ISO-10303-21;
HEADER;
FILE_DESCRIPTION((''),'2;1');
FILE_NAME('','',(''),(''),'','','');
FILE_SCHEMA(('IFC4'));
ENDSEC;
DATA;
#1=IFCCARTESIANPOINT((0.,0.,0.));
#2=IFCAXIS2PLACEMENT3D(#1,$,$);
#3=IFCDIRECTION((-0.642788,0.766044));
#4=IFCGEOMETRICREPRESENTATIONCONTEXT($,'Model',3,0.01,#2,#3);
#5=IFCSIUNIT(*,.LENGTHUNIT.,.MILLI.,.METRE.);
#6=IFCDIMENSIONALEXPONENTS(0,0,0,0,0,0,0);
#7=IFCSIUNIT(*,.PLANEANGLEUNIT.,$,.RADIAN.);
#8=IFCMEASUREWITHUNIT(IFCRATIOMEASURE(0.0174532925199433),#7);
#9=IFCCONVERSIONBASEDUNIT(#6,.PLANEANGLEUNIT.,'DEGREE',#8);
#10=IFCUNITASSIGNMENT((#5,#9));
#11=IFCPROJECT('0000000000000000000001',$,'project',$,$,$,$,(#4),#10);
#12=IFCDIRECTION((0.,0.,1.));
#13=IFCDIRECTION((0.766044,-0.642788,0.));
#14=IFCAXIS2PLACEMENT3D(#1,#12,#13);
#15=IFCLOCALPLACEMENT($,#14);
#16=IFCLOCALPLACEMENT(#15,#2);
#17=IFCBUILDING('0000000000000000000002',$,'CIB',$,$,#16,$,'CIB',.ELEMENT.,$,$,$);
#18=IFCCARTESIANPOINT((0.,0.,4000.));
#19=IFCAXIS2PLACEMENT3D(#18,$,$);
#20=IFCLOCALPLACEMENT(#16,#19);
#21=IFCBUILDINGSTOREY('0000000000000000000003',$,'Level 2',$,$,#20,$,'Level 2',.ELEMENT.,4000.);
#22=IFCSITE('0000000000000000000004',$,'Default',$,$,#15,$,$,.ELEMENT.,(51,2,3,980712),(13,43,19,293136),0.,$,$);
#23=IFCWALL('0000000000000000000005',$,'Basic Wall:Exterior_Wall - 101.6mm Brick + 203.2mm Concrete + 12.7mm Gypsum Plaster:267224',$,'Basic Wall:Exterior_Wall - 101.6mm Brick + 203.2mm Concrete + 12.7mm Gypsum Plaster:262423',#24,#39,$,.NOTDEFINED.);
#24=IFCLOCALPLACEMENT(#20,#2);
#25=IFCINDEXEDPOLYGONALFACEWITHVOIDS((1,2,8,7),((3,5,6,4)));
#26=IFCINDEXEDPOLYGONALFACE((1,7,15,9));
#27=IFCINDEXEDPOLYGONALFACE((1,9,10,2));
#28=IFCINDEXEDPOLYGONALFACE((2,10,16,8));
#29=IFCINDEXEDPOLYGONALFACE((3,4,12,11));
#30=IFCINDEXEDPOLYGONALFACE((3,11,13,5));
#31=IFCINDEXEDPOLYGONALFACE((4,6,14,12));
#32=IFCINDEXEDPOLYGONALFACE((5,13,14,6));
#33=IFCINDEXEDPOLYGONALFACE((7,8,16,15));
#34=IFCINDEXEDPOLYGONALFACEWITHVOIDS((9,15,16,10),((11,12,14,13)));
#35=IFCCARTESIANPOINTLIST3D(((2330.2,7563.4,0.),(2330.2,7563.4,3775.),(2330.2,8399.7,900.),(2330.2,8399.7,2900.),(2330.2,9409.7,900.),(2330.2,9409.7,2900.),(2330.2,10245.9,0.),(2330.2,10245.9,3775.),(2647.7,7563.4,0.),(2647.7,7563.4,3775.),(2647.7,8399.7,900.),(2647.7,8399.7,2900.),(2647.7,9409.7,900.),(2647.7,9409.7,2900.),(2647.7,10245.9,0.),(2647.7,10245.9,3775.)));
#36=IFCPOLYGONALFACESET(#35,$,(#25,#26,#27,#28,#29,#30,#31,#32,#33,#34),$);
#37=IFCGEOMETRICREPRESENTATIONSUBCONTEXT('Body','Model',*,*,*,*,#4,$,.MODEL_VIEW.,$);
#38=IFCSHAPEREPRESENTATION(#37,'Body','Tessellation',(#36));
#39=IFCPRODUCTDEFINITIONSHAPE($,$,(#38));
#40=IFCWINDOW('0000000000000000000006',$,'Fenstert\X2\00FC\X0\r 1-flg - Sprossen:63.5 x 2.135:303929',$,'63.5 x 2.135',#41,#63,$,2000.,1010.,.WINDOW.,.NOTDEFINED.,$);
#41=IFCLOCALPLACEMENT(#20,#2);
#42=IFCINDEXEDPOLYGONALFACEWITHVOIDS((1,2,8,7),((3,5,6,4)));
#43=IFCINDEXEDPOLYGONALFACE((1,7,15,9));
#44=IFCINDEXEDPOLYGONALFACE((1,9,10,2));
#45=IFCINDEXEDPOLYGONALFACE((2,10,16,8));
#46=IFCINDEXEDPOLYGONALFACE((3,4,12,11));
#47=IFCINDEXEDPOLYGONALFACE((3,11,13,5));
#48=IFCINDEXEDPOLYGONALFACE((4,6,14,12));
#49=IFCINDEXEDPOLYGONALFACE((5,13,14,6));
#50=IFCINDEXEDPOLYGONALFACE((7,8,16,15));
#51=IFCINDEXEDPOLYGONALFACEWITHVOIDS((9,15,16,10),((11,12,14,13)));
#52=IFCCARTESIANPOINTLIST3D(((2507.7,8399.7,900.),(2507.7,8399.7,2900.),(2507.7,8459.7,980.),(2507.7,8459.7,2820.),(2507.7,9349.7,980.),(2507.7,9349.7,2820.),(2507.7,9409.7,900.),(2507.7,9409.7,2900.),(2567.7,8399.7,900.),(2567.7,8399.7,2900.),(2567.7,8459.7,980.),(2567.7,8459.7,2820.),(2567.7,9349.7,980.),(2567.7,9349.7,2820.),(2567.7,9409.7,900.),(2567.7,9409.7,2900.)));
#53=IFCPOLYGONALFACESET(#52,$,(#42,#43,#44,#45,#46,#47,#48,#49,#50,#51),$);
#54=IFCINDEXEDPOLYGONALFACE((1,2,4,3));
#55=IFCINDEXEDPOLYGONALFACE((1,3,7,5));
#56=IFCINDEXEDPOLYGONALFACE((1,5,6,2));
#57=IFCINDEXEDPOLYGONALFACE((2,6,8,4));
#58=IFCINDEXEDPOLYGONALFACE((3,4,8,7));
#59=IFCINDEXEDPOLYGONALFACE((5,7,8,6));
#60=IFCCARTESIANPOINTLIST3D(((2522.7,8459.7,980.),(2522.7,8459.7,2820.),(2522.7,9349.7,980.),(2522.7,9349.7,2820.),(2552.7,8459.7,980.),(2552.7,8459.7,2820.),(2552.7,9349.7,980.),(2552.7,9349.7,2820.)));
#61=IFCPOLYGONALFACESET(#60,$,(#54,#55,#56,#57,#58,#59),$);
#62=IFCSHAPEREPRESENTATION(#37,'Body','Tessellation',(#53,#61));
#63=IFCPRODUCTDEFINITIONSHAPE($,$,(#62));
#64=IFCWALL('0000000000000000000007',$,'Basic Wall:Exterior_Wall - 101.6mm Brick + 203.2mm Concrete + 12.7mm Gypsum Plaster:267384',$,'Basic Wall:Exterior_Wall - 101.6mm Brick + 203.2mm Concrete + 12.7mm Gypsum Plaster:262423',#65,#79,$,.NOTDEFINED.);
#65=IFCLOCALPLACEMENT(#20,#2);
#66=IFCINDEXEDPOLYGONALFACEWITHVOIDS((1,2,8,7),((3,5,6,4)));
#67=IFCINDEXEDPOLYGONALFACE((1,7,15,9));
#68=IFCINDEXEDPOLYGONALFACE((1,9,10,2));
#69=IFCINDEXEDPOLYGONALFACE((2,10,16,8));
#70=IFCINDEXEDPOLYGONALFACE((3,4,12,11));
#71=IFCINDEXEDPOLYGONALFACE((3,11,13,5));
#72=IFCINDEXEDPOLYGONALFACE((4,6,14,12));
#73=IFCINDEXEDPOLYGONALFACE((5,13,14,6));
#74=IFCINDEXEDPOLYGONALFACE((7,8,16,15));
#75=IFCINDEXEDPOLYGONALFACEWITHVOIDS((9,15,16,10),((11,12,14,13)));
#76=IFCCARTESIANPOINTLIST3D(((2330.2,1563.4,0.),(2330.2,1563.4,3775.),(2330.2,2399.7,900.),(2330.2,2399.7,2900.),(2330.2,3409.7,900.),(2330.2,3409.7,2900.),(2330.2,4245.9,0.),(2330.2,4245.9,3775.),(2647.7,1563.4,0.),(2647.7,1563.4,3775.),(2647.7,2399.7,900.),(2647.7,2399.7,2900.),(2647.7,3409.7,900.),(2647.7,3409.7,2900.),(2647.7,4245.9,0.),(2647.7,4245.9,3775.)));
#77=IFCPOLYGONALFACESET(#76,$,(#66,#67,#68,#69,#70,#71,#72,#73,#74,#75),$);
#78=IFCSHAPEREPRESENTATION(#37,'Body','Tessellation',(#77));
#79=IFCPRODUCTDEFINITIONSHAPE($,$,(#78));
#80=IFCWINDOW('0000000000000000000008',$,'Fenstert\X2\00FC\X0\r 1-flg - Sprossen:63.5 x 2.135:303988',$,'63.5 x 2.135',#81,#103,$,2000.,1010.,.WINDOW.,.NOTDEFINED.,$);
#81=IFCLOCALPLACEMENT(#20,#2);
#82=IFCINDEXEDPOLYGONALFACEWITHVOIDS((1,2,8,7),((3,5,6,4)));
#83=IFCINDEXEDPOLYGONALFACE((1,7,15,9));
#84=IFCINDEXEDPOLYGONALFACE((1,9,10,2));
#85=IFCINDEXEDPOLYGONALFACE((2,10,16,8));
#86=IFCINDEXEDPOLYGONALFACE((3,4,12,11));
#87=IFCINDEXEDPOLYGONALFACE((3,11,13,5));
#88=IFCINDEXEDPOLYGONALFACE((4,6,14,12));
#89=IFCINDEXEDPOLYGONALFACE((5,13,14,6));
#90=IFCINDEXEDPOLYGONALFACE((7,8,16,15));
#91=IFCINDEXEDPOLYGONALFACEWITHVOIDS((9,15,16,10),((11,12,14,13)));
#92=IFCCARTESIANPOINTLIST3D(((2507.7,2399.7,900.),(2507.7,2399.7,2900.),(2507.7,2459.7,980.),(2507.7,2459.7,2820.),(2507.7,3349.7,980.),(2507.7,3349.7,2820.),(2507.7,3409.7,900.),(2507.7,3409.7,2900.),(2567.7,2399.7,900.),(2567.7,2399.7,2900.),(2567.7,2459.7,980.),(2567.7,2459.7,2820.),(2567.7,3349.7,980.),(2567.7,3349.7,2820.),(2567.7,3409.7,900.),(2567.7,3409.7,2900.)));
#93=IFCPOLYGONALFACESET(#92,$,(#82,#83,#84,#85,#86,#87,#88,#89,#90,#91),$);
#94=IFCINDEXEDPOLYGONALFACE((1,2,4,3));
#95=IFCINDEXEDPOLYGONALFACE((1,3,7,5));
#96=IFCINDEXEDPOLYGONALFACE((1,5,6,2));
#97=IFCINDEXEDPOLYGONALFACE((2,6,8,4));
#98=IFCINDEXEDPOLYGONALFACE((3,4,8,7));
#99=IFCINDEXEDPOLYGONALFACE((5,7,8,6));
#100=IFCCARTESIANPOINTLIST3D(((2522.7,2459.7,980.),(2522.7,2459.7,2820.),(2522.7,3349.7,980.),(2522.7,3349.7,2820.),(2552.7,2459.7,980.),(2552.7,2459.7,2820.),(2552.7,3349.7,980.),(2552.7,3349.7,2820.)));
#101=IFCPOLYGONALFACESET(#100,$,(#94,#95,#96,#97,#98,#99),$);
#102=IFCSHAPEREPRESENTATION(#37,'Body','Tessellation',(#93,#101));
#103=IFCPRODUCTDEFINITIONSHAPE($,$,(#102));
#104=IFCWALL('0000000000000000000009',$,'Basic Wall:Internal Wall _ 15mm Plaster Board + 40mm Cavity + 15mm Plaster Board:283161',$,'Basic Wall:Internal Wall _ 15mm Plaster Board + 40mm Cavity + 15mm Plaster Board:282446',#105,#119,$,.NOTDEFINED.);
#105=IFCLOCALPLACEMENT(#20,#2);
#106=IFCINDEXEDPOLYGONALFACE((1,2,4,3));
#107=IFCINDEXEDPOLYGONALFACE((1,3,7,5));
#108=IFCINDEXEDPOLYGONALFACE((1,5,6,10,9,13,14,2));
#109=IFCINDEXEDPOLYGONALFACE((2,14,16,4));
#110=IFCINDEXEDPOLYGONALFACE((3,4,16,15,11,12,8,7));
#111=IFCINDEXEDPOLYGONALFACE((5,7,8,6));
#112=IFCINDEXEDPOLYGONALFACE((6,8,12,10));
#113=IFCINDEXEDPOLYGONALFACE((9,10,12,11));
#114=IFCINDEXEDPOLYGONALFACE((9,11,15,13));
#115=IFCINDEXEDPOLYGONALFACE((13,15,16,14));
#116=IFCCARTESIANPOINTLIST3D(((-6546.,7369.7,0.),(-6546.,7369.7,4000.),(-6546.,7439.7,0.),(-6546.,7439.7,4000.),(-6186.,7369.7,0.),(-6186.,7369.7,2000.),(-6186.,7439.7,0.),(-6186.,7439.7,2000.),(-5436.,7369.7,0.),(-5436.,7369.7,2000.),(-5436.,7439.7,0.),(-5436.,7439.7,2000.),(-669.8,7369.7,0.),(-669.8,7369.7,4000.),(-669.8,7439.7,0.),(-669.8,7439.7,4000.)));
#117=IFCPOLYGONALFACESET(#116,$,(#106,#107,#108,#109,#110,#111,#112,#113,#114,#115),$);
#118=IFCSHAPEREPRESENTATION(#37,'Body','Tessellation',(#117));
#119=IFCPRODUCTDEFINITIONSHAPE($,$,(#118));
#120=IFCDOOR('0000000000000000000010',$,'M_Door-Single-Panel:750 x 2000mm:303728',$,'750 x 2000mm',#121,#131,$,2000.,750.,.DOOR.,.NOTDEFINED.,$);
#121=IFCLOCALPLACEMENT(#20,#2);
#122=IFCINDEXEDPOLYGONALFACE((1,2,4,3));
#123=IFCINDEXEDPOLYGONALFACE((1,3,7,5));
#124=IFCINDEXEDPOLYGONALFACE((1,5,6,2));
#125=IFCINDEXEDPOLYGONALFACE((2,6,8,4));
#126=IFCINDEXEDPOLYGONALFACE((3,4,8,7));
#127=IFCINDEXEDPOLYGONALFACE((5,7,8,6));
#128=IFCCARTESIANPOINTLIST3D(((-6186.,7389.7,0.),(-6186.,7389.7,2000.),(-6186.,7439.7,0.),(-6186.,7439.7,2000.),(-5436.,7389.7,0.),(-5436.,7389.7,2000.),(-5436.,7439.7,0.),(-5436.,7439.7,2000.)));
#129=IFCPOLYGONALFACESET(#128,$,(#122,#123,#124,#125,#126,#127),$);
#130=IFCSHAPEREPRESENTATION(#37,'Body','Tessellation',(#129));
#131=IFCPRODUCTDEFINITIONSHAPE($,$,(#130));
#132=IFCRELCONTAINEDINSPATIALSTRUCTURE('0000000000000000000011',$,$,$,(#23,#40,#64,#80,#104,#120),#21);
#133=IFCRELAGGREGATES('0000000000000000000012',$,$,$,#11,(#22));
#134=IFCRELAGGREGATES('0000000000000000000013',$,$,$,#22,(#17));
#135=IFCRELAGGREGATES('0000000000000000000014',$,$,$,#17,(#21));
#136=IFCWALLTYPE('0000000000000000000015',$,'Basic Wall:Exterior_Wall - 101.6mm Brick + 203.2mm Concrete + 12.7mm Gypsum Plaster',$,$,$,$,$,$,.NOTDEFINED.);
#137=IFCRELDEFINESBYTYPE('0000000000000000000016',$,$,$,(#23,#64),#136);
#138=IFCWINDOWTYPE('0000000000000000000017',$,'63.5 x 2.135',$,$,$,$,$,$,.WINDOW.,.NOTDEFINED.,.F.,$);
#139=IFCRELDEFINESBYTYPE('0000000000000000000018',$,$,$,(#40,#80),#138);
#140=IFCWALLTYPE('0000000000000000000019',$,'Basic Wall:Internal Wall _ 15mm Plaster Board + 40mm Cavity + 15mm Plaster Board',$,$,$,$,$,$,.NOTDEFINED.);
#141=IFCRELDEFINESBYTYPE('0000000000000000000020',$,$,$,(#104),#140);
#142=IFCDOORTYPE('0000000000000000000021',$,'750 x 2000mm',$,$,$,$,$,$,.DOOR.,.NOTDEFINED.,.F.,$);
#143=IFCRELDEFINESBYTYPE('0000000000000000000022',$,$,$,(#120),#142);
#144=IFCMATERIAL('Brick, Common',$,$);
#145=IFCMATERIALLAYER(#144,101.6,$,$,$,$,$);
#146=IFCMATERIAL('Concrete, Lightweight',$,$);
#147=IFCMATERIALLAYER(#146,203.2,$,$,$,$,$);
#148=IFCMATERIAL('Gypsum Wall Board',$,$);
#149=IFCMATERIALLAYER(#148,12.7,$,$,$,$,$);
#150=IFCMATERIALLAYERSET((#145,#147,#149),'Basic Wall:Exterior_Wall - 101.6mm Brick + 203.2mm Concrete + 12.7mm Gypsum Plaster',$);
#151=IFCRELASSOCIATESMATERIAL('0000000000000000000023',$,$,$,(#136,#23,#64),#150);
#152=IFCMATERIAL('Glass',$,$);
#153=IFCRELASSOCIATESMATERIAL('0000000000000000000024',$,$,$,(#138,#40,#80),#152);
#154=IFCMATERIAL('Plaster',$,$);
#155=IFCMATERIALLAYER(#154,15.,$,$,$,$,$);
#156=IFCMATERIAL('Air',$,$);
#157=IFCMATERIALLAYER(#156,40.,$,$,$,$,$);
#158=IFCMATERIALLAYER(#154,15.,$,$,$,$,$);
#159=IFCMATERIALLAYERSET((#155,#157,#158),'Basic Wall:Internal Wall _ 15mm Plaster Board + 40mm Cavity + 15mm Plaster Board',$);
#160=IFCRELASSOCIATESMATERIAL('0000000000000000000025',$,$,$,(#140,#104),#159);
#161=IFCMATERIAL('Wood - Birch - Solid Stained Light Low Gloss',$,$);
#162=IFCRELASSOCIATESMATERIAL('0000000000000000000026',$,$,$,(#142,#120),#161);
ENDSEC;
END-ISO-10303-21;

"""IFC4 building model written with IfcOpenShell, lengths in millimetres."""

from ifc_helpers import new_model, entity, si_unit, converted_unit, direction, frame, frame_2d, origin, origin_2d_with_axis, place, context, subcontext, project, spatial, polyline, rectangle, outline, extrude, clip, bounded_halfspace, source, transform, mapped, material, layer, layer_set, layer_usage, type_object, type_shapes, element, fill, save


model = new_model("IFC4")

# Units and contexts
model_context = context("Model", 3, precision=0.01, world=origin(), true_north=direction((-0.642788, 0.766044)))
body_context = subcontext(model_context, "Body", "Model", "MODEL_VIEW")
ifc_project = project(units=[si_unit("LENGTHUNIT", "METRE", prefix="MILLI"), converted_unit("PLANEANGLEUNIT", "DEGREE", entity("IfcRatioMeasure", 0.0174532925199433), si_unit("PLANEANGLEUNIT", "RADIAN"), dimensions=[0, 0, 0, 0, 0, 0, 0])], contexts=[model_context])

# Site, building, storey
site_placement = place(None, frame((0.0, 0.0, 0.0), z_axis=(0.0, 0.0, 1.0), x_axis=(0.766044, -0.642788, 0.0)))
site = spatial("IfcSite", under=ifc_project, at=site_placement, Name="Default", CompositionType="ELEMENT", RefLatitude=(51, 2, 3, 980712), RefLongitude=(13, 43, 19, 293136), RefElevation=0.0)
building_placement = place(site_placement, origin())
building = spatial("IfcBuilding", under=site, at=building_placement, Name="CIB", LongName="CIB", CompositionType="ELEMENT")
storey_placement = place(building_placement, frame((0.0, 0.0, 4000.0)))
storey = spatial("IfcBuildingStorey", under=building, at=storey_placement, Name="Level 2", LongName="Level 2", CompositionType="ELEMENT", Elevation=4000.0)

# Shared definitions
ifc_material_1 = material(Name="Brick, Common")
ifc_layer_1 = layer(ifc_material_1, 101.6)
ifc_material_2 = material(Name="Concrete, Lightweight")
ifc_layer_2 = layer(ifc_material_2, 203.2)
ifc_material_3 = material(Name="Gypsum Wall Board")
ifc_layer_3 = layer(ifc_material_3, 12.7)
ifc_layer_set_1 = layer_set([ifc_layer_1, ifc_layer_2, ifc_layer_3], Name="Basic Wall:Exterior_Wall - 101.6mm Brick + 203.2mm Concrete + 12.7mm Gypsum Plaster")
wall_type_1 = type_object("IfcWallType", Name="Basic Wall:Exterior_Wall - 101.6mm Brick + 203.2mm Concrete + 12.7mm Gypsum Plaster", PredefinedType="NOTDEFINED", material=ifc_layer_set_1)
ifc_material_4 = material(Name="Glass")
window_type = type_object("IfcWindowType", Name="63.5 x 2.135", ParameterTakesPrecedence=False, PartitioningType="NOTDEFINED", PredefinedType="WINDOW", material=ifc_material_4)
shared_shape_1 = source(origin(), body_context, "Body", "SweptSolid", [
    extrude(outline(polyline([(-1000.0, -505.0), (1000.0, -505.0), (1000.0, 505.0), (-1000.0, 505.0), (-1000.0, -505.0)]), holes=[polyline([(-920.0, -445.0), (-920.0, 445.0), (920.0, 445.0), (920.0, -445.0), (-920.0, -445.0)])]), frame((505.0, 177.5, 1000.0), z_axis=(0.0, 1.0, 0.0), x_axis=(0.0, 0.0, -1.0)), (0.0, 0.0, 1.0), 60.0),
    extrude(rectangle(XDim=30.0, YDim=890.0, at=origin_2d_with_axis()), frame((505.0, 207.5, 80.0), z_axis=(0.0, 0.0, 1.0), x_axis=(0.0, 1.0, 0.0)), (0.0, 0.0, 1.0), 1840.0),
])
type_shapes(window_type, [shared_shape_1])

# Walls, openings, windows
ifc_layer_usage_1 = layer_usage(ifc_layer_set_1, "AXIS2", "NEGATIVE", 158.8)
wall_1_placement = place(storey_placement, frame((2489.0, 10245.9, 0.0), z_axis=(0.0, 0.0, 1.0), x_axis=(0.0, -1.0, 0.0)))
wall_1 = element("IfcWall", 1, at=wall_1_placement, inside=storey, type_object=wall_type_1, material=ifc_layer_usage_1, Name="Basic Wall:Exterior_Wall - 101.6mm Brick + 203.2mm Concrete + 12.7mm Gypsum Plaster:267224", ObjectType="Basic Wall:Exterior_Wall - 101.6mm Brick + 203.2mm Concrete + 12.7mm Gypsum Plaster:262423", PredefinedType="NOTDEFINED", context=body_context, shape_type="Clipping", body=[
    clip(extrude(rectangle(XDim=2682.5, YDim=317.5, at=frame_2d((1341.2, 0.0), x_axis=(-1.0, 0.0))), origin(), (0.0, 0.0, 1.0), 3775.0), bounded_halfspace(frame((0.0, -158.8, 3775.0), z_axis=(0.0, 0.0, -1.0), x_axis=(-1.0, 0.0, 0.0)), True, frame((0.0, -158.8, 3775.0)), polyline([(0.0, 0.0), (2682.5, 0.0), (2682.5, 317.5), (0.0, 317.5), (0.0, 0.0)]))),
])
opening_1_placement = place(wall_1_placement, frame((1846.2, 158.8, 900.0)))
opening_1 = element("IfcOpeningElement", 2, at=opening_1_placement, cuts=wall_1, ObjectType="Opening", PredefinedType="OPENING", context=body_context, shape_type="SweptSolid", body=[
    extrude(rectangle(XDim=2000.0, YDim=1010.0, at=frame_2d((1000.0, 505.0), x_axis=(1.0, 0.0))), frame((0.0, 0.0, 0.0), z_axis=(0.0, -1.0, 0.0), x_axis=(0.0, 0.0, 1.0)), (0.0, 0.0, 1.0), 317.5),
])
window_1_placement = place(opening_1_placement, frame((-1010.0, -317.5, 0.0)))
window_1 = element("IfcWindow", 3, at=window_1_placement, inside=storey, type_object=window_type, material=ifc_material_4, Name="Fenstertür 1-flg - Sprossen:63.5 x 2.135:303929", ObjectType="63.5 x 2.135", OverallHeight=2000.0, OverallWidth=1010.0, PartitioningType="NOTDEFINED", PredefinedType="WINDOW", context=body_context, shape_type="MappedRepresentation", body=[
    mapped(shared_shape_1, transform((0.0, 0.0, 0.0), scale=1.0)),
])
fill(opening_1, window_1)
ifc_layer_usage_2 = layer_usage(ifc_layer_set_1, "AXIS2", "POSITIVE", -158.8)
wall_2_placement = place(storey_placement, frame((2489.0, 1563.4, 0.0), z_axis=(0.0, 0.0, 1.0), x_axis=(0.0, 1.0, 0.0)))
wall_2 = element("IfcWall", 4, at=wall_2_placement, inside=storey, type_object=wall_type_1, material=ifc_layer_usage_2, Name="Basic Wall:Exterior_Wall - 101.6mm Brick + 203.2mm Concrete + 12.7mm Gypsum Plaster:267384", ObjectType="Basic Wall:Exterior_Wall - 101.6mm Brick + 203.2mm Concrete + 12.7mm Gypsum Plaster:262423", PredefinedType="NOTDEFINED", context=body_context, shape_type="Clipping", body=[
    clip(extrude(rectangle(XDim=2682.5, YDim=317.5, at=frame_2d((1341.2, 0.0), x_axis=(-1.0, 0.0))), origin(), (0.0, 0.0, 1.0), 3775.0), bounded_halfspace(frame((0.0, -158.8, 3775.0), z_axis=(0.0, 0.0, -1.0), x_axis=(1.0, 0.0, 0.0)), True, frame((0.0, -158.8, 3775.0)), polyline([(0.0, 0.0), (2682.5, 0.0), (2682.5, 317.5), (0.0, 317.5), (0.0, 0.0)]))),
])
opening_2_placement = place(wall_2_placement, frame((836.3, -158.7, 900.0)))
opening_2 = element("IfcOpeningElement", 5, at=opening_2_placement, cuts=wall_2, ObjectType="Opening", PredefinedType="OPENING", context=body_context, shape_type="SweptSolid", body=[
    extrude(rectangle(XDim=2000.0, YDim=1010.0, at=frame_2d((1000.0, 505.0), x_axis=(1.0, 0.0))), frame((0.0, 0.0, 0.0), z_axis=(0.0, 1.0, 0.0), x_axis=(0.0, 0.0, 1.0)), (0.0, 0.0, 1.0), 317.5),
])
window_2_placement = place(opening_2_placement, frame((1010.0, 317.5, 0.0), z_axis=(0.0, 0.0, 1.0), x_axis=(-1.0, 0.0, 0.0)))
window_2 = element("IfcWindow", 6, at=window_2_placement, inside=storey, type_object=window_type, material=ifc_material_4, Name="Fenstertür 1-flg - Sprossen:63.5 x 2.135:303988", ObjectType="63.5 x 2.135", OverallHeight=2000.0, OverallWidth=1010.0, PartitioningType="NOTDEFINED", PredefinedType="WINDOW", context=body_context, shape_type="MappedRepresentation", body=[
    mapped(shared_shape_1, transform((0.0, 0.0, 0.0), scale=1.0)),
])
fill(opening_2, window_2)

# Wall, opening, door
ifc_material_5 = material(Name="Plaster")
ifc_layer_4 = layer(ifc_material_5, 15.0)
ifc_material_6 = material(Name="Air")
ifc_layer_5 = layer(ifc_material_6, 40.0)
ifc_layer_6 = layer(ifc_material_5, 15.0)
ifc_layer_set_2 = layer_set([ifc_layer_4, ifc_layer_5, ifc_layer_6], Name="Basic Wall:Internal Wall _ 15mm Plaster Board + 40mm Cavity + 15mm Plaster Board")
ifc_layer_usage_3 = layer_usage(ifc_layer_set_2, "AXIS2", "NEGATIVE", 35.0)
wall_type_2 = type_object("IfcWallType", Name="Basic Wall:Internal Wall _ 15mm Plaster Board + 40mm Cavity + 15mm Plaster Board", PredefinedType="NOTDEFINED", material=ifc_layer_set_2)
wall_3_placement = place(storey_placement, frame((-669.8, 7404.7, 0.0), z_axis=(0.0, 0.0, 1.0), x_axis=(-1.0, 0.0, 0.0)))
wall_3 = element("IfcWall", 7, at=wall_3_placement, inside=storey, type_object=wall_type_2, material=ifc_layer_usage_3, Name="Basic Wall:Internal Wall _ 15mm Plaster Board + 40mm Cavity + 15mm Plaster Board:283161", ObjectType="Basic Wall:Internal Wall _ 15mm Plaster Board + 40mm Cavity + 15mm Plaster Board:282446", PredefinedType="NOTDEFINED", context=body_context, shape_type="SweptSolid", body=[
    extrude(rectangle(XDim=5876.2, YDim=70.0, at=frame_2d((2938.1, 0.0), x_axis=(-1.0, 0.0))), origin(), (0.0, 0.0, 1.0), 4000.0),
])
opening_3_placement = place(wall_3_placement, frame((5516.2, 35.0, 0.0)))
opening_3 = element("IfcOpeningElement", 8, at=opening_3_placement, cuts=wall_3, ObjectType="Opening", PredefinedType="OPENING", context=body_context, shape_type="SweptSolid", body=[
    extrude(rectangle(XDim=750.0, YDim=2000.0, at=frame_2d((1000.0, 375.0), x_axis=(0.0, -1.0))), frame((0.0, 0.0, 0.0), z_axis=(0.0, -1.0, 0.0), x_axis=(0.0, 0.0, 1.0)), (0.0, 0.0, 1.0), 70.0),
])
ifc_material_7 = material(Name="Wood - Birch - Solid Stained Light Low Gloss")
door_type = type_object("IfcDoorType", Name="750 x 2000mm", OperationType="NOTDEFINED", ParameterTakesPrecedence=False, PredefinedType="DOOR", material=ifc_material_7)
shared_shape_2 = source(origin(), body_context, "Body", "SweptSolid", [
    extrude(rectangle(XDim=750.0, YDim=50.0, at=origin_2d_with_axis()), frame((375.0, 45.0, 0.0)), (0.0, 0.0, 1.0), 2000.0),
])
type_shapes(door_type, [shared_shape_2])
door_placement = place(opening_3_placement, frame((0.0, 0.0, 0.0), z_axis=(0.0, 0.0, 1.0), x_axis=(-1.0, 0.0, 0.0)))
door = element("IfcDoor", 9, at=door_placement, inside=storey, type_object=door_type, material=ifc_material_7, Name="M_Door-Single-Panel:750 x 2000mm:303728", ObjectType="750 x 2000mm", OperationType="NOTDEFINED", OverallHeight=2000.0, OverallWidth=750.0, PredefinedType="DOOR", context=body_context, shape_type="MappedRepresentation", body=[
    mapped(shared_shape_2, transform((0.0, 0.0, 0.0), scale=1.0)),
])
fill(opening_3, door)

save(model, "model.ifc")
